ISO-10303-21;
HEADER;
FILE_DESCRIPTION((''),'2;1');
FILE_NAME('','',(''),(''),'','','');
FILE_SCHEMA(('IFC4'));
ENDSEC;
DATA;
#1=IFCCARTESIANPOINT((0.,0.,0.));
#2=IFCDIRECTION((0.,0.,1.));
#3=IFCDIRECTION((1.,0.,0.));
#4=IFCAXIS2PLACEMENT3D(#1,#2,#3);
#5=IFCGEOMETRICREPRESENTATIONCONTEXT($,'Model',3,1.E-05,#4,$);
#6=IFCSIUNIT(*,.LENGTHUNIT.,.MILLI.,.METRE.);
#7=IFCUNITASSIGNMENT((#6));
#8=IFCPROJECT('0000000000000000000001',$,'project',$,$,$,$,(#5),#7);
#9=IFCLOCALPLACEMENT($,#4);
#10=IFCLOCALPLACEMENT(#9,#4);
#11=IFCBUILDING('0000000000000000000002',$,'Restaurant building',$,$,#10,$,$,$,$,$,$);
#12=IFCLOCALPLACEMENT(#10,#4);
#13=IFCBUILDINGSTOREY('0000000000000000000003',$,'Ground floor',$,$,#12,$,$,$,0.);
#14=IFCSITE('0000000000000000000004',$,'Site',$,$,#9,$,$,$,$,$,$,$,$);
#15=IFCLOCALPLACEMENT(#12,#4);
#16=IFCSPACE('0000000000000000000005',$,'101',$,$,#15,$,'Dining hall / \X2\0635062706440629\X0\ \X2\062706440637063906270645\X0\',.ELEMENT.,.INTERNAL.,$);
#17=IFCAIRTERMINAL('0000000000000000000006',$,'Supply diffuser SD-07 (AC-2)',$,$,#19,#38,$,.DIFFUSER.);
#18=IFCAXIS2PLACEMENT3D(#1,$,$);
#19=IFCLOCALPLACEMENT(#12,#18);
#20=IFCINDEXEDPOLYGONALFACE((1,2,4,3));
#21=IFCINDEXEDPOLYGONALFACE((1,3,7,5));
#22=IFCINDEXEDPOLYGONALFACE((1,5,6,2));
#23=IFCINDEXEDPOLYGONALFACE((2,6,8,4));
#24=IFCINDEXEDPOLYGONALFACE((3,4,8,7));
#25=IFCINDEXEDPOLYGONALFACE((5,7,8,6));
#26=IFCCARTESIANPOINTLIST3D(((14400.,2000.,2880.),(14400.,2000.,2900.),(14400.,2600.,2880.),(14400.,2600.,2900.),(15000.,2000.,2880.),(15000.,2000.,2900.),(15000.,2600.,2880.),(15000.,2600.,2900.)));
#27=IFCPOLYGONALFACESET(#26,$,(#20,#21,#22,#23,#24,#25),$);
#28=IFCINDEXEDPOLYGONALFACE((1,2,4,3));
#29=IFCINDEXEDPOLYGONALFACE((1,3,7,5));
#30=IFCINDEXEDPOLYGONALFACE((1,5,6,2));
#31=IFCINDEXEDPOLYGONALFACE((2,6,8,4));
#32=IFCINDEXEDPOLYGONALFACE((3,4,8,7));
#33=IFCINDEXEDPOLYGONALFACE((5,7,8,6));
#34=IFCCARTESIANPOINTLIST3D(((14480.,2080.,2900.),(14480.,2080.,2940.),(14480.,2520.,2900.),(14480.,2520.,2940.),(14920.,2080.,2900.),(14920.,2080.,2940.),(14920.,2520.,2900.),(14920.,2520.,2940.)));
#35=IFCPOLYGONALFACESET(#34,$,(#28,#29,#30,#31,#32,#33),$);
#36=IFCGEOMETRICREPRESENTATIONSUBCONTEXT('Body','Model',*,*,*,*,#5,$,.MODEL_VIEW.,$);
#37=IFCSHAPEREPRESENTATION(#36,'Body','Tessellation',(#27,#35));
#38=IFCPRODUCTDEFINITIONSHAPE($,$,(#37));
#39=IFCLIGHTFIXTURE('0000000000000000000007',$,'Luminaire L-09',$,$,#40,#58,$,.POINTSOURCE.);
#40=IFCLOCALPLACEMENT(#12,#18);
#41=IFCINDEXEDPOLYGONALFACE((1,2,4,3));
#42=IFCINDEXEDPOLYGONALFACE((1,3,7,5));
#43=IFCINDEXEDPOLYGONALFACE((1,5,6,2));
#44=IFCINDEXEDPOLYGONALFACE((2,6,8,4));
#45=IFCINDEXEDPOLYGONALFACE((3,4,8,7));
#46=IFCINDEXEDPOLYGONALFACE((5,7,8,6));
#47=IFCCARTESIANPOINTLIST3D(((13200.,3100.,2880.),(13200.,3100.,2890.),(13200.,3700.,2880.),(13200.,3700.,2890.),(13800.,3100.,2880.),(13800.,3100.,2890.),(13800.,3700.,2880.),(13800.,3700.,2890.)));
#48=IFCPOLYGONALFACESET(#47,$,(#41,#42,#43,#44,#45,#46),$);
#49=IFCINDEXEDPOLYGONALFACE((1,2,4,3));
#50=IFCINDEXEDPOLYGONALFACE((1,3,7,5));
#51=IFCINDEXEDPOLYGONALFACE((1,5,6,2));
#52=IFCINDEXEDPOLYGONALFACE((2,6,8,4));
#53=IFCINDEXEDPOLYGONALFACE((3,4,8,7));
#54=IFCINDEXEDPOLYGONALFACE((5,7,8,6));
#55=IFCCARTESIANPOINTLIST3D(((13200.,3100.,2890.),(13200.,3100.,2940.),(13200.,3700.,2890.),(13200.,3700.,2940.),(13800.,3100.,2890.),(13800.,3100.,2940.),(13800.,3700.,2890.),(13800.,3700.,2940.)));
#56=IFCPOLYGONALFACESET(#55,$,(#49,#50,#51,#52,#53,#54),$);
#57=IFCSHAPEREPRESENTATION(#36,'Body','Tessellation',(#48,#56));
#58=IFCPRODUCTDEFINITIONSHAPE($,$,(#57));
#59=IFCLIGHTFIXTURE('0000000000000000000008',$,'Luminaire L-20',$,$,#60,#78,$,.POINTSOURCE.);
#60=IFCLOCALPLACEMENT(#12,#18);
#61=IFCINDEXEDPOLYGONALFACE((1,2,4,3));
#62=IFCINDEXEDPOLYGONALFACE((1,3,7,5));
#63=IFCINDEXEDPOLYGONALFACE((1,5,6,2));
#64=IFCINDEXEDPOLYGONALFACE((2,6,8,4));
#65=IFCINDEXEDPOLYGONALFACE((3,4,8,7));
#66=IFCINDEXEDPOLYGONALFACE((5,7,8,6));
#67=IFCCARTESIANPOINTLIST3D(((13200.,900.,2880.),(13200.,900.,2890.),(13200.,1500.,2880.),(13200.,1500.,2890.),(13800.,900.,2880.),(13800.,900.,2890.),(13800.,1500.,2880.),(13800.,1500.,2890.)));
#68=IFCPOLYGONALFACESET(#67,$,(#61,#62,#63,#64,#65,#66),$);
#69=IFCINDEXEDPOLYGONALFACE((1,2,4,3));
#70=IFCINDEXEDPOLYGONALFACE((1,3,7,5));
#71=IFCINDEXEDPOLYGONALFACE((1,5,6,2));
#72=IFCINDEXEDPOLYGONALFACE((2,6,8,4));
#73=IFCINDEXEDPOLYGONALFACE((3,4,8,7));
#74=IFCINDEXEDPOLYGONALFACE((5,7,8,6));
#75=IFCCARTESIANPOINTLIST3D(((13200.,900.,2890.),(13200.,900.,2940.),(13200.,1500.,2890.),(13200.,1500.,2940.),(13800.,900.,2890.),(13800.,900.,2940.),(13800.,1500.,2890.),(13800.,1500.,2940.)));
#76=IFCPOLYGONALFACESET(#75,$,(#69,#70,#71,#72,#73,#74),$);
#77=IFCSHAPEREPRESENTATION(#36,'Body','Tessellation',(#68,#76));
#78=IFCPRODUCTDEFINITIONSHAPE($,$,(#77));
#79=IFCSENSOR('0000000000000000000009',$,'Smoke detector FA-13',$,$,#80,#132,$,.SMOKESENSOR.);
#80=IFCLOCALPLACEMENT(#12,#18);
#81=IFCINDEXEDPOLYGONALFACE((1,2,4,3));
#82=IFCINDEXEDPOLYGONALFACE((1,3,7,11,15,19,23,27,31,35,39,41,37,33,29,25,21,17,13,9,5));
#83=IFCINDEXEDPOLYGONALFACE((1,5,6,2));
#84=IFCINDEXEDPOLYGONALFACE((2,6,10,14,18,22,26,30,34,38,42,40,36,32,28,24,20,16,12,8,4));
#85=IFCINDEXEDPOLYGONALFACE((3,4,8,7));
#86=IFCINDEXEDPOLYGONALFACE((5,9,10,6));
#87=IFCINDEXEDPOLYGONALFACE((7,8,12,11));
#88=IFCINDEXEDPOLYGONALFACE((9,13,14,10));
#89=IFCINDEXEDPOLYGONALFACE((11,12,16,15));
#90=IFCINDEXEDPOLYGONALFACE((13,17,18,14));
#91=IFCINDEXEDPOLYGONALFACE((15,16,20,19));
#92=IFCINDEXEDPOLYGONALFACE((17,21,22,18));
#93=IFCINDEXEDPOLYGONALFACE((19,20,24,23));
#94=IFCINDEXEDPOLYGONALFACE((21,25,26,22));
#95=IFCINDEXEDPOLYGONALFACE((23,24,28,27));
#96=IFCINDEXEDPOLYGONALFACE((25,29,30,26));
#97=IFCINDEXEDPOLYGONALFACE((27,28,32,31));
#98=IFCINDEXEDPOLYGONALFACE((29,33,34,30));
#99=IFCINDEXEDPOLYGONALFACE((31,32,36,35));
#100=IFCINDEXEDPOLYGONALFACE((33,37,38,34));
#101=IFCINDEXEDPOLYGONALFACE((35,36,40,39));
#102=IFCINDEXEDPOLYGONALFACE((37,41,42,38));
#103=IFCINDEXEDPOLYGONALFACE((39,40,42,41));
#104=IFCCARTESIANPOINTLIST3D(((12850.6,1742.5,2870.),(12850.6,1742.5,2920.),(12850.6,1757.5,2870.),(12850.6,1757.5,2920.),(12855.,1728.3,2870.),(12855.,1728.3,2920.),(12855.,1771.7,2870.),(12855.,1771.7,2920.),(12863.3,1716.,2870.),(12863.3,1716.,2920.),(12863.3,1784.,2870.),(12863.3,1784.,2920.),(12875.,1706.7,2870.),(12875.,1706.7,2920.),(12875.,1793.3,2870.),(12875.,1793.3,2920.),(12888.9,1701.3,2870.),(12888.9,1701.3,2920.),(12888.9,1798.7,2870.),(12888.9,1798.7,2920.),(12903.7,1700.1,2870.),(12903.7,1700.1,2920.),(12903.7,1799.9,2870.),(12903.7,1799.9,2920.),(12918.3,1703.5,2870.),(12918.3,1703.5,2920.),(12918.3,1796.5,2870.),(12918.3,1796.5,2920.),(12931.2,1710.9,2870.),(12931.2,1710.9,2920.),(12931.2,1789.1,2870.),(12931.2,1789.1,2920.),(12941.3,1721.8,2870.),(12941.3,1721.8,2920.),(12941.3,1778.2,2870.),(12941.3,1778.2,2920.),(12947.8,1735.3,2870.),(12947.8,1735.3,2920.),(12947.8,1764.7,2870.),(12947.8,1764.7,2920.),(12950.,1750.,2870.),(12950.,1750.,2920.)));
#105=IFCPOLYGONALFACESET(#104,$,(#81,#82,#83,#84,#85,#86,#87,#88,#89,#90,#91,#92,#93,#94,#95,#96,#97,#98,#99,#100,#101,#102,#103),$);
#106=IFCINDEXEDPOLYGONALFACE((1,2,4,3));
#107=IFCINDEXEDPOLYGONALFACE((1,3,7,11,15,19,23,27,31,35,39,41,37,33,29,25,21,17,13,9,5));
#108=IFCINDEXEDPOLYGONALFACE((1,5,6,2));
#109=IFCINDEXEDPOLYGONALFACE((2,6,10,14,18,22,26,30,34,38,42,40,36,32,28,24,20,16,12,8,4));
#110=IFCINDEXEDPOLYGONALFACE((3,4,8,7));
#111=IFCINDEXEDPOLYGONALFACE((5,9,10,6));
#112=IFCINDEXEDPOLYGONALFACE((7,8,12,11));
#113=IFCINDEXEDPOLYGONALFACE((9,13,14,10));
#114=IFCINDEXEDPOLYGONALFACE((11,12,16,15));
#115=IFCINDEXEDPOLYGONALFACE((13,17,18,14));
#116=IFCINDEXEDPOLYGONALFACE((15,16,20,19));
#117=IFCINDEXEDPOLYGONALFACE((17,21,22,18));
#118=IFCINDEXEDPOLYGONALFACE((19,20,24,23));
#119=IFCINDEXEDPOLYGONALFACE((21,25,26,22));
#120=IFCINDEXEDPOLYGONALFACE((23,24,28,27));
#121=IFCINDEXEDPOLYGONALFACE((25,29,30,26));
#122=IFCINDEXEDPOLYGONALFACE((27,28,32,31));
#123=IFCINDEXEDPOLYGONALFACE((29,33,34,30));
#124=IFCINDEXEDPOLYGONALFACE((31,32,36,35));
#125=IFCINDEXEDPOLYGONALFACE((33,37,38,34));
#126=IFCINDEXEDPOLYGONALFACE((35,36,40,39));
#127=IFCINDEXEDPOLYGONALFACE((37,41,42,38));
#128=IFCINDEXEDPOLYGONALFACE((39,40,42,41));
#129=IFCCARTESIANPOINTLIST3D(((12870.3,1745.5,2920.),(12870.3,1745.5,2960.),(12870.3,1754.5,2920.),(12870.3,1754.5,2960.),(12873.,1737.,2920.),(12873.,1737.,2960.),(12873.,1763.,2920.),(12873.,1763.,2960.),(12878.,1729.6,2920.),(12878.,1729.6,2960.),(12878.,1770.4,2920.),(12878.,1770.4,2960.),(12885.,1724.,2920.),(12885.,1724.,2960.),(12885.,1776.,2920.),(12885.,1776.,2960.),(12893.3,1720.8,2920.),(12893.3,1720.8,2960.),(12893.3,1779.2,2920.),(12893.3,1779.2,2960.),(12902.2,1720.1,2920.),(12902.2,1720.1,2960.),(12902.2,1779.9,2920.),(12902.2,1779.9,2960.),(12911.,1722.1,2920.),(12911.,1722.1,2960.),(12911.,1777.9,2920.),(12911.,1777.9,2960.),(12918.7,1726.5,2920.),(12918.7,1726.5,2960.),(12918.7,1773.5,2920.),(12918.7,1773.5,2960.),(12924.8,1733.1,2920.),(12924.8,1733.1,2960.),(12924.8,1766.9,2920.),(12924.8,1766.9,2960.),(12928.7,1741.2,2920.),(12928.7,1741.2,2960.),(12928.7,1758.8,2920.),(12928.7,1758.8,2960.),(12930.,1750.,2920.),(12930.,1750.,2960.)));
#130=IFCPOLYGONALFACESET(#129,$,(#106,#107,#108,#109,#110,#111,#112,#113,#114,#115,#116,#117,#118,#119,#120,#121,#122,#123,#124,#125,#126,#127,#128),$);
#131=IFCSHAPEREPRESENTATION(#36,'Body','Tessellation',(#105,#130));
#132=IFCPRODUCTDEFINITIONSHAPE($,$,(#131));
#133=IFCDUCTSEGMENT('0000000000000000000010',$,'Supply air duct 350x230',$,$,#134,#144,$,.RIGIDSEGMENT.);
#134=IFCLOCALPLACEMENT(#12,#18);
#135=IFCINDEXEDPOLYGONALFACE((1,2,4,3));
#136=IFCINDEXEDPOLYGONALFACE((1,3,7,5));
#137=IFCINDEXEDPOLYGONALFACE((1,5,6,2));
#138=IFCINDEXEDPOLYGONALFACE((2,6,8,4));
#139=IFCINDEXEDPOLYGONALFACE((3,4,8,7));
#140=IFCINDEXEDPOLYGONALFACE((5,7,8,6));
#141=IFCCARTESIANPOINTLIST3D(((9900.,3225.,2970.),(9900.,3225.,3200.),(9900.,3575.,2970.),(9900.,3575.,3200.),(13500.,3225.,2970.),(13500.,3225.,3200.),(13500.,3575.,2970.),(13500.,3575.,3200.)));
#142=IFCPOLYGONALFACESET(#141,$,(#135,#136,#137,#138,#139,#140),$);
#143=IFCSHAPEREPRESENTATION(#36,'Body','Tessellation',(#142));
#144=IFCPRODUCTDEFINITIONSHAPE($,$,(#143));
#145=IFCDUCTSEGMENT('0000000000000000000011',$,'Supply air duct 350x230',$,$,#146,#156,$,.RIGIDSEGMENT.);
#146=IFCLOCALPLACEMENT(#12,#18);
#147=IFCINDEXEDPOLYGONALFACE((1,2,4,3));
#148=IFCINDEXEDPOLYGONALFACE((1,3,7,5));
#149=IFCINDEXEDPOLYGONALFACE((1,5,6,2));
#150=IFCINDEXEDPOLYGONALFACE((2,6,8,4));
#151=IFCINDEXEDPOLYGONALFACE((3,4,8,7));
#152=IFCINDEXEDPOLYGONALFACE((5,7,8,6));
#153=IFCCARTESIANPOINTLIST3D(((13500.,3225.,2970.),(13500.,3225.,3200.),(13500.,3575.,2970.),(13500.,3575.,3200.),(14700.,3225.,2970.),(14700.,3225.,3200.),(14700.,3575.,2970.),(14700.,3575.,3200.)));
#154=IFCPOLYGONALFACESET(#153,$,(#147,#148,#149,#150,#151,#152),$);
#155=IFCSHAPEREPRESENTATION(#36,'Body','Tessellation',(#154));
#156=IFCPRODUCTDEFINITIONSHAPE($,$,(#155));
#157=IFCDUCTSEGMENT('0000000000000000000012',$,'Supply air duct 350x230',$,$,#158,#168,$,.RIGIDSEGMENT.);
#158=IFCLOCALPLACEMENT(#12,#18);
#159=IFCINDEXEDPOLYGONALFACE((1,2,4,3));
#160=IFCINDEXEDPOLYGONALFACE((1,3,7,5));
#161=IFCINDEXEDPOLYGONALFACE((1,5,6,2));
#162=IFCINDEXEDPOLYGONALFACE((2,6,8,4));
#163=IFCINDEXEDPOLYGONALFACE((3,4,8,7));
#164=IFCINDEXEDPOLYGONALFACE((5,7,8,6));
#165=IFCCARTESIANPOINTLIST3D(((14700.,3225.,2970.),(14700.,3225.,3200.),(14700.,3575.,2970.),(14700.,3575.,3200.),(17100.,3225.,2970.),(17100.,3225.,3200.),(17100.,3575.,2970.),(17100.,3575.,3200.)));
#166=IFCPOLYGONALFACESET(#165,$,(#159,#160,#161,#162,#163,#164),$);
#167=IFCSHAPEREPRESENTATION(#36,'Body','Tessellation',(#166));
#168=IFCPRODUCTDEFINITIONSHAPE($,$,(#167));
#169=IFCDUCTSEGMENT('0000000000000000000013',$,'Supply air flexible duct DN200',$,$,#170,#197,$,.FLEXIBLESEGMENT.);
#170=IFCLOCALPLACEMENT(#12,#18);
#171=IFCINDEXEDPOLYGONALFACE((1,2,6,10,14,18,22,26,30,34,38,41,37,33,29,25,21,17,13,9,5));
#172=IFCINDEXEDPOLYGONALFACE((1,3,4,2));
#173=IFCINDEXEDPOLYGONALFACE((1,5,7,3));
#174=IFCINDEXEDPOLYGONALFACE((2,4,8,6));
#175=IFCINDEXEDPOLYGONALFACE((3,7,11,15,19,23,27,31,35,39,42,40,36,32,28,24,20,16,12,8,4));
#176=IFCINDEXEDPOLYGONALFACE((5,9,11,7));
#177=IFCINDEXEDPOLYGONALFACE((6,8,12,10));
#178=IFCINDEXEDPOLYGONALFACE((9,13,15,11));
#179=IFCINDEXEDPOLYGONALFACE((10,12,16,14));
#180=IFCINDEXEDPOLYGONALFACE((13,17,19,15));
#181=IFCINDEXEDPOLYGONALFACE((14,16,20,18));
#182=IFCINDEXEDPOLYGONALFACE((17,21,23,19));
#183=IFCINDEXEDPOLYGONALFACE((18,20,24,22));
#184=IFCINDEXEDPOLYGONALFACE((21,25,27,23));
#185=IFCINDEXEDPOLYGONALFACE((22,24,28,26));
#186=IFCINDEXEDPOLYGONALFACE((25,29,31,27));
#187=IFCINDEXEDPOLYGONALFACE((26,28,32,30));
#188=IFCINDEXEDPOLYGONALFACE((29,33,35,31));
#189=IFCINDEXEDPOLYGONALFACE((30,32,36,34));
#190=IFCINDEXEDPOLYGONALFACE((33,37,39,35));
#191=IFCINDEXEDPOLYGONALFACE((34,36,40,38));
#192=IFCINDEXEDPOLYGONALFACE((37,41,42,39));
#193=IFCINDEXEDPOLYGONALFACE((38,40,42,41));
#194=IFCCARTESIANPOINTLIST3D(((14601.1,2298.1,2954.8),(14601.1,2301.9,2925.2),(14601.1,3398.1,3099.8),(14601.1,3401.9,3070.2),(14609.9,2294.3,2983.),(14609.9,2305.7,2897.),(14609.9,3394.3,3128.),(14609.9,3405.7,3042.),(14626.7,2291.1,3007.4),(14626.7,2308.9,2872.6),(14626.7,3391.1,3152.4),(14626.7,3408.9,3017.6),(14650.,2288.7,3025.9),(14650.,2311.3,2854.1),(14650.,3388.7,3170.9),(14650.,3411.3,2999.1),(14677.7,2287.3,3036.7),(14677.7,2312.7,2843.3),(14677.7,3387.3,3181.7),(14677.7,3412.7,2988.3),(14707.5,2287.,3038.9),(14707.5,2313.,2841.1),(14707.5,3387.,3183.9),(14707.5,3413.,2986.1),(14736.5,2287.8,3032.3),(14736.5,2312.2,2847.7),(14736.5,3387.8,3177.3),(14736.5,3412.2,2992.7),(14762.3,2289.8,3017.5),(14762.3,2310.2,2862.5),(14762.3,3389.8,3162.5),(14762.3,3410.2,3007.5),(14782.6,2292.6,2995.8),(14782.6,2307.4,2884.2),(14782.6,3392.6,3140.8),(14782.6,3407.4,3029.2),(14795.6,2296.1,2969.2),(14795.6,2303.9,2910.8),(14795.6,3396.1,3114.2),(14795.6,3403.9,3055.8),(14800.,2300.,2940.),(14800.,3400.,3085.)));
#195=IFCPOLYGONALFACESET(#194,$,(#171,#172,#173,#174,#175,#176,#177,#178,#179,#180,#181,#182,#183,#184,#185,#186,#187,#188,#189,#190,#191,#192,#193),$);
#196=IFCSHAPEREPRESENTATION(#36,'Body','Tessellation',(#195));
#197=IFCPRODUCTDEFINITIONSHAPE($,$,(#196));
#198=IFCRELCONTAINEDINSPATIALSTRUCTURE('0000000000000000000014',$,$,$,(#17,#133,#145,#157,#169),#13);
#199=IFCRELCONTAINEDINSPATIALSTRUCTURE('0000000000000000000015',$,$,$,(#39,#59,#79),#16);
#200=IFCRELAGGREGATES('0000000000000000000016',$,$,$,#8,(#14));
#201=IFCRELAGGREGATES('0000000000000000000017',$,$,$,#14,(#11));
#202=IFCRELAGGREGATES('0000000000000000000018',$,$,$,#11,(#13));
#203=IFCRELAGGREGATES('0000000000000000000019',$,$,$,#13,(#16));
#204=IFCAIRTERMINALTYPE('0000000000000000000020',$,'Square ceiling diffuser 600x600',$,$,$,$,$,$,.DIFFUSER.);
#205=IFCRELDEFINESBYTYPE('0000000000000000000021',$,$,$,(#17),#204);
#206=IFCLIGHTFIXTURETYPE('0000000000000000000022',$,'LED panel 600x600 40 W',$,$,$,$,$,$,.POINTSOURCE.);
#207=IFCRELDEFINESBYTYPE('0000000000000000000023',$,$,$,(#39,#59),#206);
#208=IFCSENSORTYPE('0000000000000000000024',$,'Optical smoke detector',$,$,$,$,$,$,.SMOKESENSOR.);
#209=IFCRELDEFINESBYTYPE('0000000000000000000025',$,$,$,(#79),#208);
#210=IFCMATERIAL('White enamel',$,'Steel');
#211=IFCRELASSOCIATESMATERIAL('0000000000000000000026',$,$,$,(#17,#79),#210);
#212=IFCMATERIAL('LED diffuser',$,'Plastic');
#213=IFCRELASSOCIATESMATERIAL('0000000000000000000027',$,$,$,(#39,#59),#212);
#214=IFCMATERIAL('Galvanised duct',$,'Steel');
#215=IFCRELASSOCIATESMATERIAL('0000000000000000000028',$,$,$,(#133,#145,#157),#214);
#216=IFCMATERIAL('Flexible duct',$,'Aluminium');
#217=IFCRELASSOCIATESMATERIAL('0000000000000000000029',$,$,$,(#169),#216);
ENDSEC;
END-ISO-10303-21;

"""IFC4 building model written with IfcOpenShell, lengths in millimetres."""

from ifc_helpers import new_model, si_unit, frame, origin, origin_with_axes, origin_2d, place, context, subcontext, project, spatial, rectangle, circle, extrude, source, transform, mapped, material, type_object, type_shapes, element, save


model = new_model("IFC4")

# Units and contexts
model_context = context("Model", 3, precision=1e-05, world=origin_with_axes())
body_context = subcontext(model_context, "Body", "Model", "MODEL_VIEW")
ifc_project = project(units=[si_unit("LENGTHUNIT", "METRE", prefix="MILLI")], contexts=[model_context])

# Site, building, storey
site_placement = place(None, origin_with_axes())
site = spatial("IfcSite", under=ifc_project, at=site_placement, Name="Site")
building_placement = place(site_placement, origin_with_axes())
building = spatial("IfcBuilding", under=site, at=building_placement, Name="Restaurant building")
storey_placement = place(building_placement, origin_with_axes())
storey = spatial("IfcBuildingStorey", under=building, at=storey_placement, Name="Ground floor", Elevation=0.0)

# Air terminal
ifc_material_1 = material(Name="White enamel", Category="Steel")
air_terminal_type = type_object("IfcAirTerminalType", Name="Square ceiling diffuser 600x600", PredefinedType="DIFFUSER")
shared_shape_1 = source(origin(), body_context, "Body", "SweptSolid", [
    extrude(rectangle(XDim=600.0, YDim=600.0, at=origin_2d()), frame((0.0, 0.0, -60.0)), (0.0, 0.0, 1.0), 20.0),
    extrude(rectangle(XDim=440.0, YDim=440.0, at=origin_2d()), frame((0.0, 0.0, -40.0)), (0.0, 0.0, 1.0), 40.0),
])
type_shapes(air_terminal_type, [shared_shape_1])
air_terminal_placement = place(storey_placement, frame((14700.0, 2300.0, 2940.0)))
element("IfcAirTerminal", 1, at=air_terminal_placement, inside=storey, type_object=air_terminal_type, material=ifc_material_1, Name="Supply diffuser SD-07 (AC-2)", PredefinedType="DIFFUSER", context=body_context, shape_type="MappedRepresentation", body=[
    mapped(shared_shape_1, transform((0.0, 0.0, 0.0))),
])

# Shared definitions
space_placement = place(storey_placement, origin_with_axes())
space = spatial("IfcSpace", under=storey, at=space_placement, Name="101", LongName="Dining hall / صالة الطعام", CompositionType="ELEMENT", PredefinedType="INTERNAL")

# Light fixtures
ifc_material_2 = material(Name="LED diffuser", Category="Plastic")
light_fixture_type = type_object("IfcLightFixtureType", Name="LED panel 600x600 40 W", PredefinedType="POINTSOURCE")
shared_shape_2 = source(origin(), body_context, "Body", "SweptSolid", [
    extrude(rectangle(XDim=600.0, YDim=600.0, at=origin_2d()), frame((0.0, 0.0, -60.0)), (0.0, 0.0, 1.0), 10.0),
    extrude(rectangle(XDim=600.0, YDim=600.0, at=origin_2d()), frame((0.0, 0.0, -50.0)), (0.0, 0.0, 1.0), 50.0),
])
type_shapes(light_fixture_type, [shared_shape_2])
for number, where, name in (
    (2, (13500.0, 3400.0, 2940.0), "Luminaire L-09"),
    (3, (13500.0, 1200.0, 2940.0), "Luminaire L-20"),
):
    element("IfcLightFixture", number, at=place(storey_placement, frame(where)), inside=space, type_object=light_fixture_type, material=ifc_material_2, Name=name, PredefinedType="POINTSOURCE", context=body_context, shape_type="MappedRepresentation", body=[
        mapped(shared_shape_2, transform((0.0, 0.0, 0.0))),
    ])

# Sensor
sensor_type = type_object("IfcSensorType", Name="Optical smoke detector", PredefinedType="SMOKESENSOR")
shared_shape_3 = source(origin(), body_context, "Body", "SweptSolid", [
    extrude(circle(Radius=50.0, at=origin_2d()), frame((0.0, 0.0, -90.0)), (0.0, 0.0, 1.0), 50.0),
    extrude(circle(Radius=30.0, at=origin_2d()), frame((0.0, 0.0, -40.0)), (0.0, 0.0, 1.0), 40.0),
])
type_shapes(sensor_type, [shared_shape_3])
sensor_placement = place(storey_placement, frame((12900.0, 1750.0, 2960.0)))
element("IfcSensor", 4, at=sensor_placement, inside=space, type_object=sensor_type, material=ifc_material_1, Name="Smoke detector FA-13", PredefinedType="SMOKESENSOR", context=body_context, shape_type="MappedRepresentation", body=[
    mapped(shared_shape_3, transform((0.0, 0.0, 0.0))),
])

# Duct segments
ifc_material_3 = material(Name="Galvanised duct", Category="Steel")
duct_segment_1_placement = place(storey_placement, frame((13500.0, 3400.0, 3085.0)))
element("IfcDuctSegment", 5, at=duct_segment_1_placement, inside=storey, material=ifc_material_3, Name="Supply air duct 350x230", PredefinedType="RIGIDSEGMENT", context=body_context, shape_type="SweptSolid", body=[
    extrude(rectangle(XDim=350.0, YDim=230.0, at=origin_2d()), frame((0.0, 0.0, 0.0), z_axis=(-1.0, 0.0, 0.0), x_axis=(0.0, -1.0, 0.0)), (0.0, 0.0, 1.0), 3600.0),
])
duct_segment_2_placement = place(storey_placement, frame((13500.0, 3400.0, 3085.0)))
element("IfcDuctSegment", 6, at=duct_segment_2_placement, inside=storey, material=ifc_material_3, Name="Supply air duct 350x230", PredefinedType="RIGIDSEGMENT", context=body_context, shape_type="SweptSolid", body=[
    extrude(rectangle(XDim=350.0, YDim=230.0, at=origin_2d()), frame((0.0, 0.0, 0.0), z_axis=(1.0, 0.0, 0.0), x_axis=(0.0, 1.0, 0.0)), (0.0, 0.0, 1.0), 1200.0),
])
duct_segment_3_placement = place(storey_placement, frame((14700.0, 3400.0, 3085.0)))
element("IfcDuctSegment", 7, at=duct_segment_3_placement, inside=storey, material=ifc_material_3, Name="Supply air duct 350x230", PredefinedType="RIGIDSEGMENT", context=body_context, shape_type="SweptSolid", body=[
    extrude(rectangle(XDim=350.0, YDim=230.0, at=origin_2d()), frame((0.0, 0.0, 0.0), z_axis=(1.0, 0.0, 0.0), x_axis=(0.0, 1.0, 0.0)), (0.0, 0.0, 1.0), 2400.0),
])
ifc_material_4 = material(Name="Flexible duct", Category="Aluminium")
duct_segment_4_placement = place(storey_placement, frame((14700.0, 3400.0, 3085.0)))
element("IfcDuctSegment", 8, at=duct_segment_4_placement, inside=storey, material=ifc_material_4, Name="Supply air flexible duct DN200", PredefinedType="FLEXIBLESEGMENT", context=body_context, shape_type="SweptSolid", body=[
    extrude(circle(Radius=100.0, at=origin_2d()), frame((0.0, 0.0, 0.0), z_axis=(0.0, -0.991424, -0.130688), x_axis=(1.0, 0.0, 0.0)), (0.0, 0.0, 1.0), 1109.5),
])

save(model, "model.ifc")
